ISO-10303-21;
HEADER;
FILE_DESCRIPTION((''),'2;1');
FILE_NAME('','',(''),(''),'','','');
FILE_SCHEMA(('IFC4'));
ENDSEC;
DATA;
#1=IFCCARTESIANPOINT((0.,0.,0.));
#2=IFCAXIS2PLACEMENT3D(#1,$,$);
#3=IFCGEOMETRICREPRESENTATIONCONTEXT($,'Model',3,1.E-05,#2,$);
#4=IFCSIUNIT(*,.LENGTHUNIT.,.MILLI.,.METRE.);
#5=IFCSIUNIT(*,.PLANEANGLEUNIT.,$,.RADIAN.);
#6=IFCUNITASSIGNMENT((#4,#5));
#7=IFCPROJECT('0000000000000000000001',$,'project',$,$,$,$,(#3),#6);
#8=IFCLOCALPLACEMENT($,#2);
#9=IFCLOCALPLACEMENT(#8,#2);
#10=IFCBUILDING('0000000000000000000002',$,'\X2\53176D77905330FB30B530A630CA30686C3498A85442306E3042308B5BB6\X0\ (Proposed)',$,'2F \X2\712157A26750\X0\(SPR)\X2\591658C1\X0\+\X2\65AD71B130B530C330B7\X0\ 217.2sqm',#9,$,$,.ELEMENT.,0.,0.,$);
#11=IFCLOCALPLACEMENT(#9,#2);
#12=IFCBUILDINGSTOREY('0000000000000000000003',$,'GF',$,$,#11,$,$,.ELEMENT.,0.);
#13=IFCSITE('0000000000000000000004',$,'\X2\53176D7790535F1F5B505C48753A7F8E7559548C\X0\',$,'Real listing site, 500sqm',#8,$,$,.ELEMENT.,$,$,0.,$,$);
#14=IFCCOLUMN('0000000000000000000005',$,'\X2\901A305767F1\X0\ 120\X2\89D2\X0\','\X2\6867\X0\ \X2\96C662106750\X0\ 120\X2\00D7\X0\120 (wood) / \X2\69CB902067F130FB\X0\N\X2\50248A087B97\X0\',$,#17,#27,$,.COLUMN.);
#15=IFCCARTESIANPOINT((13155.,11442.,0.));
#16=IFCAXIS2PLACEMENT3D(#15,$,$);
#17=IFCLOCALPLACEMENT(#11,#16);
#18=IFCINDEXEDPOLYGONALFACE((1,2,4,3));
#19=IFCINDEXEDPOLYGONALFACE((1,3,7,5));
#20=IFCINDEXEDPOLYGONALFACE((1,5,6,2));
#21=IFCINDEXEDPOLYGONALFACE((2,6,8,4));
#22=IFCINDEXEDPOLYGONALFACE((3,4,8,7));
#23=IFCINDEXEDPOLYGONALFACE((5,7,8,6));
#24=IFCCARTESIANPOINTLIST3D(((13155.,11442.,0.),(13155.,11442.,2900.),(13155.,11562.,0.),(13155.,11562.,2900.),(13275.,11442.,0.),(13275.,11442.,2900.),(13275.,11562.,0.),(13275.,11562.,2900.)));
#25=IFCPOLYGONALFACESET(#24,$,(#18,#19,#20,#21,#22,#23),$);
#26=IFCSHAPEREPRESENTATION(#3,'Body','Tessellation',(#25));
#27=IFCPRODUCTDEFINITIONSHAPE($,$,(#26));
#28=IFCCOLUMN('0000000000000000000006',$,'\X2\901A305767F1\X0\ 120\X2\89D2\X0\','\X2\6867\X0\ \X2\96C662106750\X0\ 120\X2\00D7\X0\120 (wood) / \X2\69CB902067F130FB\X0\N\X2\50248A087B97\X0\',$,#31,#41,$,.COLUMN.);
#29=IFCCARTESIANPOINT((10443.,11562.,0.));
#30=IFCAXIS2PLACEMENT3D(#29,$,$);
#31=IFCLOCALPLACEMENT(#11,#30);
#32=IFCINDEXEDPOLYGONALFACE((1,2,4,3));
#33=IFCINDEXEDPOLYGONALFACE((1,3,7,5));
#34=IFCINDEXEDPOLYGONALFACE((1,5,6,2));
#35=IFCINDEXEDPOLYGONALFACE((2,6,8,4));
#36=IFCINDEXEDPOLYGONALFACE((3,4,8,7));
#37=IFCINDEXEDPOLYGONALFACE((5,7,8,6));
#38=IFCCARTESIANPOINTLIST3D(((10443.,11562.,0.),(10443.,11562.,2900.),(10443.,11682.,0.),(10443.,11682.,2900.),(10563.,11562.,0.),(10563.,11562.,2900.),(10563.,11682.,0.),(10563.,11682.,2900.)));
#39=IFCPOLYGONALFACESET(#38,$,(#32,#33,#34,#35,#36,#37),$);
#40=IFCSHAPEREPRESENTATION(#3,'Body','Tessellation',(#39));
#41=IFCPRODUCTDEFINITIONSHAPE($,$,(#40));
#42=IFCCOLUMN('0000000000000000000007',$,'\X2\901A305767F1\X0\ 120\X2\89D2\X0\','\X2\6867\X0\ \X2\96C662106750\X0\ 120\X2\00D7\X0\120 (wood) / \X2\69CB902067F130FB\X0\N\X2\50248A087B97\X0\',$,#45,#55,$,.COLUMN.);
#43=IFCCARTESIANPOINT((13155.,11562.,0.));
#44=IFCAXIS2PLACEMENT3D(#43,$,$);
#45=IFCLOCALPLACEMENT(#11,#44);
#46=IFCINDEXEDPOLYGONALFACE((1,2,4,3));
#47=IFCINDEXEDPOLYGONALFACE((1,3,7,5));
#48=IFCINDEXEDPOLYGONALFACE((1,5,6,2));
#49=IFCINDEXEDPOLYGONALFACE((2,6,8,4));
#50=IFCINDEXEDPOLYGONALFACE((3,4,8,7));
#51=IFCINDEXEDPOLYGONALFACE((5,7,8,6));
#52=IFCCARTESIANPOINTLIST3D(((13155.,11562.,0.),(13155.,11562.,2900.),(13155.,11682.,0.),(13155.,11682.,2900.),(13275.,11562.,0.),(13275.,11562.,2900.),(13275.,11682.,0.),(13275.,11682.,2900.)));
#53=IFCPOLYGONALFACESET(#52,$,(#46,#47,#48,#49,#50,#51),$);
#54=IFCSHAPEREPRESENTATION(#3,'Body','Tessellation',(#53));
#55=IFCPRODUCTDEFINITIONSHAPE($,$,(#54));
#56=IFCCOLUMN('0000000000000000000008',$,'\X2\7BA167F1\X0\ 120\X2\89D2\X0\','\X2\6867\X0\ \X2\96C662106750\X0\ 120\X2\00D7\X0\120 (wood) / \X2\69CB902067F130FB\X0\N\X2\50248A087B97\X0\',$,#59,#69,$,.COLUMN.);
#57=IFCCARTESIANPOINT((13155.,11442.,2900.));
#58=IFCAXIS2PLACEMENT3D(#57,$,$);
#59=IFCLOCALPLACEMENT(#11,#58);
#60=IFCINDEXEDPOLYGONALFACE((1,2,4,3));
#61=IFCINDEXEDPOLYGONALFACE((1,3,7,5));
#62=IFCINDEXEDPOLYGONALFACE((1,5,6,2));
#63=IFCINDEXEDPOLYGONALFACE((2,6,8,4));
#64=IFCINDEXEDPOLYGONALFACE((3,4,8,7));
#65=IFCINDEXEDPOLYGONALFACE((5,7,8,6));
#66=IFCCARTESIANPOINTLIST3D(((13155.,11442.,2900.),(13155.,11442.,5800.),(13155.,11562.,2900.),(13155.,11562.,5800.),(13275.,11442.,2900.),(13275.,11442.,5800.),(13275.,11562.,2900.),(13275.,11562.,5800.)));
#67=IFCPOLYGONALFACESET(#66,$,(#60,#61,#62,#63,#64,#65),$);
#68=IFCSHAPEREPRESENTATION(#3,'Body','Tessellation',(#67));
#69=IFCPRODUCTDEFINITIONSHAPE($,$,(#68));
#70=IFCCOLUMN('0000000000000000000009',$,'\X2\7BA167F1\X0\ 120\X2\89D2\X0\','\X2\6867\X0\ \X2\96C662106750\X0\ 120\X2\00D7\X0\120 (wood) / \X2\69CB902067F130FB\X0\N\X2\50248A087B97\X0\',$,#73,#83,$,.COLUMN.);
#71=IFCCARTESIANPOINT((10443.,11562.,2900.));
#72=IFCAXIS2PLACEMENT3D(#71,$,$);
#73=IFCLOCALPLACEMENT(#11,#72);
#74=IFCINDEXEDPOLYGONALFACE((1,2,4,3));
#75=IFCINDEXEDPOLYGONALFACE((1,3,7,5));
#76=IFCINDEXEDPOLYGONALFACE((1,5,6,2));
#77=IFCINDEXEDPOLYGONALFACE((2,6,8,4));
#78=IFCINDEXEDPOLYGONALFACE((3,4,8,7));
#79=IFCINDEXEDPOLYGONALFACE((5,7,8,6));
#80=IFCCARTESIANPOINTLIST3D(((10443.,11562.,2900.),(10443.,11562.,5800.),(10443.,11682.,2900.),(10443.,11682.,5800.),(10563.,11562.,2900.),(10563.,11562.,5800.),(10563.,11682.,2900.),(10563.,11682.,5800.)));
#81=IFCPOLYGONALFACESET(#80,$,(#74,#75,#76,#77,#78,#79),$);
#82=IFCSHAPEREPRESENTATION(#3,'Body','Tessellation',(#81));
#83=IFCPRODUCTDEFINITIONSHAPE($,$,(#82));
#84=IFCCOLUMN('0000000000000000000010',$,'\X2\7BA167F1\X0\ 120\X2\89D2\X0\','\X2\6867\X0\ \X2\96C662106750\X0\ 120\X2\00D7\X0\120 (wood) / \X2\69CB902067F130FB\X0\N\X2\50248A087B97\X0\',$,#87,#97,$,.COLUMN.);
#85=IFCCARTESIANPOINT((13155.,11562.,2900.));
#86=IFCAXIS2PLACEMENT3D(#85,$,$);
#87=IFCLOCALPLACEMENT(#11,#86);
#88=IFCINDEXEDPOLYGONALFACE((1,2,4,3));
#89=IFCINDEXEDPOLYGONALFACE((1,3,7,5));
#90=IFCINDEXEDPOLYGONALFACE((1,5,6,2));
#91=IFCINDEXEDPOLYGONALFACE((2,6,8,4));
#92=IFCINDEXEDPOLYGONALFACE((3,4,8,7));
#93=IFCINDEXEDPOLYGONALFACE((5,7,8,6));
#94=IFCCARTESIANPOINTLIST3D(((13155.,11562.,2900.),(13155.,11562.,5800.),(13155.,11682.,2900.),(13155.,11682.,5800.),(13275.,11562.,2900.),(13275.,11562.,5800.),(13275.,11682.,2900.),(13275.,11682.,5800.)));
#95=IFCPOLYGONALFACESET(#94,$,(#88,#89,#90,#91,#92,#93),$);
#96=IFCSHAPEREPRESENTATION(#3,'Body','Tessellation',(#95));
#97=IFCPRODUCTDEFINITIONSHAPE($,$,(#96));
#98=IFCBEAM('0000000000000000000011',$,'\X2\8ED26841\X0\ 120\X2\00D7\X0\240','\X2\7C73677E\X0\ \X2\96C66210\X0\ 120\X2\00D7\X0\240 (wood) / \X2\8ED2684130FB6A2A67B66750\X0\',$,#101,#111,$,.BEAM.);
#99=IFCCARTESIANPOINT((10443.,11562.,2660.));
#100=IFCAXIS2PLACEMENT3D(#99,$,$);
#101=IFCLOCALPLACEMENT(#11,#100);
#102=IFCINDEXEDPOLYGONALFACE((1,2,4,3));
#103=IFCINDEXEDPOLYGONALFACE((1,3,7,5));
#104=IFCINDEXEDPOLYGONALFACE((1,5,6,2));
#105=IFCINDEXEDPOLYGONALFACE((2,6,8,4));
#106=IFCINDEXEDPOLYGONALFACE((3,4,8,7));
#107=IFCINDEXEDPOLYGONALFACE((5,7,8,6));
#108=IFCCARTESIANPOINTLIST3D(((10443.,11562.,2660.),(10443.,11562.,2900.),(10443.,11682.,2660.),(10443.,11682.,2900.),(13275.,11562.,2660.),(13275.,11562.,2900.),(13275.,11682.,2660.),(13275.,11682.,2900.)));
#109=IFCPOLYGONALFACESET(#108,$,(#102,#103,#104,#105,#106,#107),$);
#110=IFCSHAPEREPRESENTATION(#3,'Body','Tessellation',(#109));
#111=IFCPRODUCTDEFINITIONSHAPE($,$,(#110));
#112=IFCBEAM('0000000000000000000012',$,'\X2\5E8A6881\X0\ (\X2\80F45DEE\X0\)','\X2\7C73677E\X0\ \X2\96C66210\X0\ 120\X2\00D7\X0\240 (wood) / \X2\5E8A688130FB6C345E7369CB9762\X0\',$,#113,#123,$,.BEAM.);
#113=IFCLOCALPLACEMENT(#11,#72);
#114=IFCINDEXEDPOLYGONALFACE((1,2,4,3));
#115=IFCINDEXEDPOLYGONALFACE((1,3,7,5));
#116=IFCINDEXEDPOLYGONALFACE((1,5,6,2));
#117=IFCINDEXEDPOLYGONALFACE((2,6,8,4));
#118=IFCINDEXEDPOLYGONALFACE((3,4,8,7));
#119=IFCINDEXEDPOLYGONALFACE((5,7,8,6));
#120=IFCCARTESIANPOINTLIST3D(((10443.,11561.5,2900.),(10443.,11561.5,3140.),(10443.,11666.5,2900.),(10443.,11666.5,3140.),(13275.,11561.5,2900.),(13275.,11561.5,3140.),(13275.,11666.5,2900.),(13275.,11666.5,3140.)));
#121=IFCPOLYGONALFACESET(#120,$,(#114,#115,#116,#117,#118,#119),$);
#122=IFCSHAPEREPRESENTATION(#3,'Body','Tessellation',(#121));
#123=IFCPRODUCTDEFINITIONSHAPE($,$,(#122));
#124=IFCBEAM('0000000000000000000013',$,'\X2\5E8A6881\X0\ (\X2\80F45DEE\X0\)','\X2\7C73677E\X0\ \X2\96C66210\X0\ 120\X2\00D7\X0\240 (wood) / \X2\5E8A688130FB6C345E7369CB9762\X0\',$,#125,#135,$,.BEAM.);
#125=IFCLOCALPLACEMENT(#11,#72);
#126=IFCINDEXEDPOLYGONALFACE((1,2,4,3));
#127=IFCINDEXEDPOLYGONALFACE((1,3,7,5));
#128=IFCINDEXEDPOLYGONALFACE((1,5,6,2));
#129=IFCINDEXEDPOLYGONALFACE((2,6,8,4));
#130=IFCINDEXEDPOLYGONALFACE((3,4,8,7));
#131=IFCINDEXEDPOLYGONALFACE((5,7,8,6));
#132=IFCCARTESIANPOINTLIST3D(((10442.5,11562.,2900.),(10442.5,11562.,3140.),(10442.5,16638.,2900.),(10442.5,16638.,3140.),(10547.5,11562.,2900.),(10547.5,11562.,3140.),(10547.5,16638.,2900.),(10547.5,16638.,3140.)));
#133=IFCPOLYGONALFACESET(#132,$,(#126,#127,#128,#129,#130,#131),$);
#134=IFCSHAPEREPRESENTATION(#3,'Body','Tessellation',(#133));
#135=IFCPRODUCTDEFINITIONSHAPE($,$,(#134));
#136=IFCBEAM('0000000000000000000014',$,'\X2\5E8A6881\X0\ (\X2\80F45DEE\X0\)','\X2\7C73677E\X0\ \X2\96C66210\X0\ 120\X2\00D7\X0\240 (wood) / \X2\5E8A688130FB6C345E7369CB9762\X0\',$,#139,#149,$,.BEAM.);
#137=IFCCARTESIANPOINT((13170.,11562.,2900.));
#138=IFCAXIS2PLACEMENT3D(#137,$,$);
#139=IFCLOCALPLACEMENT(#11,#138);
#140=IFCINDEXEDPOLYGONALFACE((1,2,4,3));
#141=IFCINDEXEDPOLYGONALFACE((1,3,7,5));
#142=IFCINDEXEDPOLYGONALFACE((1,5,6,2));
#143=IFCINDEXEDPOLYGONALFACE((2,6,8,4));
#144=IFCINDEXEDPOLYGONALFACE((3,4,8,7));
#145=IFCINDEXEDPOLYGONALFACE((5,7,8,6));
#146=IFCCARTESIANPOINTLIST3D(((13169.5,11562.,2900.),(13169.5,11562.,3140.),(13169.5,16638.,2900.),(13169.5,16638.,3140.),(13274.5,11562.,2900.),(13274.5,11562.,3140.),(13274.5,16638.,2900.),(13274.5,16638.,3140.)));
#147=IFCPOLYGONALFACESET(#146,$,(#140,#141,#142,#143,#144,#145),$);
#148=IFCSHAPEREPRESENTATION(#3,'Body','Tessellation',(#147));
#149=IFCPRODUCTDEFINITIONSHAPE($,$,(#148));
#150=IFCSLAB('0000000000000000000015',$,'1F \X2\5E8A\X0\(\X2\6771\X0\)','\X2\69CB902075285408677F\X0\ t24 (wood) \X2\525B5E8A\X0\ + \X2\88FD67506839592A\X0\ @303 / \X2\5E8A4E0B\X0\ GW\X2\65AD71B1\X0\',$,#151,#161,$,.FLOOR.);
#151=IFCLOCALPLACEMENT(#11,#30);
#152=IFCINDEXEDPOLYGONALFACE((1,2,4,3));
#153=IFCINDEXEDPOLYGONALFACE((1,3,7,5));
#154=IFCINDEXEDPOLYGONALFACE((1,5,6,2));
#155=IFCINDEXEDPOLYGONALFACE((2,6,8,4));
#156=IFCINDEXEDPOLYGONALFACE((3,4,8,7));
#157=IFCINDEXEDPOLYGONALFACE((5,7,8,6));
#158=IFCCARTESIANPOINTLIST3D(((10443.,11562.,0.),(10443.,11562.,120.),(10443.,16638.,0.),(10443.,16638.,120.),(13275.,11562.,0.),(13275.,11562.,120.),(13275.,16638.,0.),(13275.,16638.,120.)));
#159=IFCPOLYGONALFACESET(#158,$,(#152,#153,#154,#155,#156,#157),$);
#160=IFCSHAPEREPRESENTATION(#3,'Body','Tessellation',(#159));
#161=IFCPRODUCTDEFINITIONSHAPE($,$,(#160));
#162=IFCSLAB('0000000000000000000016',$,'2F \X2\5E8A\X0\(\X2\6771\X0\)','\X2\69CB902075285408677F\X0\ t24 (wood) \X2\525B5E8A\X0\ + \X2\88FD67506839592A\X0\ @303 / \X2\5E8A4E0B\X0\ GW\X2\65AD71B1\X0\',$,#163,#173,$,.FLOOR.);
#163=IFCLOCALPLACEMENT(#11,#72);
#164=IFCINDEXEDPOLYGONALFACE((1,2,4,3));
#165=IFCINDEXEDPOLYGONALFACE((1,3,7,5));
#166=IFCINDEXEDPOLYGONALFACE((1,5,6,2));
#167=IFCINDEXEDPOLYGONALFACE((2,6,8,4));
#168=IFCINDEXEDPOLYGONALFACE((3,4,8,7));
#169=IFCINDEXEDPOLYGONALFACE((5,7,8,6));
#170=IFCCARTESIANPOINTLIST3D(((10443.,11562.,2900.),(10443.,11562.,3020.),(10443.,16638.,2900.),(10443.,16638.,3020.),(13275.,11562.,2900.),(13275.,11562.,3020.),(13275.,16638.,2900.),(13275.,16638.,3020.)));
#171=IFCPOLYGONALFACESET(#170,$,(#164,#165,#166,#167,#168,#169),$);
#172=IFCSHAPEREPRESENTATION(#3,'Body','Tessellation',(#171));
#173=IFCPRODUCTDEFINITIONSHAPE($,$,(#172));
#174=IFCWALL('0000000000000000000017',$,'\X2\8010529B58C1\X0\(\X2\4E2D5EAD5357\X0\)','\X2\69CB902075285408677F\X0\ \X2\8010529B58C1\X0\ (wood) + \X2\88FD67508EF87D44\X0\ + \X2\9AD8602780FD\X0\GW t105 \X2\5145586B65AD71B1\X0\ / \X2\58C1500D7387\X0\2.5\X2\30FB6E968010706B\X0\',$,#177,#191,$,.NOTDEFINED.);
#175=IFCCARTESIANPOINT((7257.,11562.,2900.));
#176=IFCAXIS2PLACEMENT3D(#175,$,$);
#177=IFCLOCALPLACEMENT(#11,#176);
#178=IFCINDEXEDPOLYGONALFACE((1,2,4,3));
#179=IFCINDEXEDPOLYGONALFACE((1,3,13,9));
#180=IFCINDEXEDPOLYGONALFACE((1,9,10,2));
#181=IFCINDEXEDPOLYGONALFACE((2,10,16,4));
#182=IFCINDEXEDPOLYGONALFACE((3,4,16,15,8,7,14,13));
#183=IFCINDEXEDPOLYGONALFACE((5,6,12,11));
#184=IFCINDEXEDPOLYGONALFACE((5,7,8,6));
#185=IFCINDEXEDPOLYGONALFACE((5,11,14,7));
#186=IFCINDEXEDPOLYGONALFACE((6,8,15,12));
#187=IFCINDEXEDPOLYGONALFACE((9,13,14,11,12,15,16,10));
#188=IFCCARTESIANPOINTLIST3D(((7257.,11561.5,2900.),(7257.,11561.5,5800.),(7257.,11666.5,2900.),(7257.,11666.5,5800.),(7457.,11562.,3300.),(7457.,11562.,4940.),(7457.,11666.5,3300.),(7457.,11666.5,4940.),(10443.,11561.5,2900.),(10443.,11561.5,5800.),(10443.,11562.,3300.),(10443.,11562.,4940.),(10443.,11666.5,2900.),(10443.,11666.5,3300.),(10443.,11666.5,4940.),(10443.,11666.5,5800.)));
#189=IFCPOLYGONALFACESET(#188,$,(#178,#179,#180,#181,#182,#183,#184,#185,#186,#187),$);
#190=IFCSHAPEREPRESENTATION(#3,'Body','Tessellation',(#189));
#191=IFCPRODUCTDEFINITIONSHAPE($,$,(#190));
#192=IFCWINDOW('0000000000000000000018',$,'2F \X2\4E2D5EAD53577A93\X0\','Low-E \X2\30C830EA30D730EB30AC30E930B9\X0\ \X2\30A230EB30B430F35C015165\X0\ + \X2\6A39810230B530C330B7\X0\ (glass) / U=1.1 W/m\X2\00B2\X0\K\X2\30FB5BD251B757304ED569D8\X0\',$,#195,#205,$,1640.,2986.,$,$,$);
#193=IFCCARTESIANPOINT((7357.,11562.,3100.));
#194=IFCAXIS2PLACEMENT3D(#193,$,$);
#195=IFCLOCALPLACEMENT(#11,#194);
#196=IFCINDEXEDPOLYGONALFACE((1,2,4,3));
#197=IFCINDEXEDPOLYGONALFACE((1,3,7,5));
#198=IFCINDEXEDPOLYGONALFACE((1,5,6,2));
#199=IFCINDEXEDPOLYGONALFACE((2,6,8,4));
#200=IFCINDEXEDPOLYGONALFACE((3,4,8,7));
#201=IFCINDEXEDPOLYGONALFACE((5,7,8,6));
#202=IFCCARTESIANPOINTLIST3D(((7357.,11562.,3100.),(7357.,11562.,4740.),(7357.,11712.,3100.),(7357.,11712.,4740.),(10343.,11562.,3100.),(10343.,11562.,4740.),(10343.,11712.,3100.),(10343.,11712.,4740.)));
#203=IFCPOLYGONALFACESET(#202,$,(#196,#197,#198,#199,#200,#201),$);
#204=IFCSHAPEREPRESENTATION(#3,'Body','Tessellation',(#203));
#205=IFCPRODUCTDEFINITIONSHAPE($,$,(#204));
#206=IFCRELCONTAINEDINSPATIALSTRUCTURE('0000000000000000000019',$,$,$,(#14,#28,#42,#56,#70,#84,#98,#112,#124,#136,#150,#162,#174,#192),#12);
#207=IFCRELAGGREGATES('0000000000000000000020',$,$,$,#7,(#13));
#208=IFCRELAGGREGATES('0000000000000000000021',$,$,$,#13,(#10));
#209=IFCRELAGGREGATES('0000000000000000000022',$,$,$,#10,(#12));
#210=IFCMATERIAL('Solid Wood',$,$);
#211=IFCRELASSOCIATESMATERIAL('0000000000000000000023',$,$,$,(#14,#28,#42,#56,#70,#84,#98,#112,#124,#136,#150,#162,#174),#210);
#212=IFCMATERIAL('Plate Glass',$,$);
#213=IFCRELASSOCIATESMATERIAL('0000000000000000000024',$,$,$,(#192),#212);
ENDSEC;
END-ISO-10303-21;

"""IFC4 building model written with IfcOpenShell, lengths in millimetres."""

from ifc_helpers import new_model, si_unit, frame, frame_2d, origin, place, context, project, spatial, rectangle, extrude, material, element, fill, save


model = new_model("IFC4")

# Units and contexts
model_context = context("Model", 3, precision=1e-05, world=origin())
ifc_project = project(units=[si_unit("LENGTHUNIT", "METRE", prefix="MILLI"), si_unit("PLANEANGLEUNIT", "RADIAN")], contexts=[model_context])

# Site, building, storey
site_placement = place(None, origin())
site = spatial("IfcSite", under=ifc_project, at=site_placement, Name="北海道弟子屈町美留和", ObjectType="Real listing site, 500sqm", CompositionType="ELEMENT", RefElevation=0.0)
building_placement = place(site_placement, origin())
building = spatial("IfcBuilding", under=site, at=building_placement, Name="北海道・サウナと水風呂のある家 (Proposed)", ObjectType="2F 無垢材(SPR)外壁+断熱サッシ 217.2sqm", CompositionType="ELEMENT", ElevationOfRefHeight=0.0, ElevationOfTerrain=0.0)
storey_placement = place(building_placement, origin())
storey = spatial("IfcBuildingStorey", under=building, at=storey_placement, Name="GF", CompositionType="ELEMENT", Elevation=0.0)

# Columns
ifc_material_1 = material(Name="Solid Wood")
column_1_placement = place(storey_placement, frame((13155.0, 11442.0, 0.0)))
element("IfcColumn", 1, at=column_1_placement, inside=storey, material=ifc_material_1, Name="通し柱 120角", Description="桧 集成材 120×120 (wood) / 構造柱・N値計算", PredefinedType="COLUMN", context=model_context, shape_type="SweptSolid", body=[
    extrude(rectangle(XDim=120.0, YDim=120.0, at=frame_2d((60.0, 60.0))), frame((13155.0, 11442.0, 0.0)), (0.0, 0.0, 1.0), 2900.0),
])
column_2_placement = place(storey_placement, frame((10443.0, 11562.0, 0.0)))
element("IfcColumn", 2, at=column_2_placement, inside=storey, material=ifc_material_1, Name="通し柱 120角", Description="桧 集成材 120×120 (wood) / 構造柱・N値計算", PredefinedType="COLUMN", context=model_context, shape_type="SweptSolid", body=[
    extrude(rectangle(XDim=120.0, YDim=120.0, at=frame_2d((60.0, 60.0))), frame((10443.0, 11562.0, 0.0)), (0.0, 0.0, 1.0), 2900.0),
])
column_3_placement = place(storey_placement, frame((13155.0, 11562.0, 0.0)))
element("IfcColumn", 3, at=column_3_placement, inside=storey, material=ifc_material_1, Name="通し柱 120角", Description="桧 集成材 120×120 (wood) / 構造柱・N値計算", PredefinedType="COLUMN", context=model_context, shape_type="SweptSolid", body=[
    extrude(rectangle(XDim=120.0, YDim=120.0, at=frame_2d((60.0, 60.0))), frame((13155.0, 11562.0, 0.0)), (0.0, 0.0, 1.0), 2900.0),
])
column_4_placement = place(storey_placement, frame((13155.0, 11442.0, 2900.0)))
element("IfcColumn", 4, at=column_4_placement, inside=storey, material=ifc_material_1, Name="管柱 120角", Description="桧 集成材 120×120 (wood) / 構造柱・N値計算", PredefinedType="COLUMN", context=model_context, shape_type="SweptSolid", body=[
    extrude(rectangle(XDim=120.0, YDim=120.0, at=frame_2d((60.0, 60.0))), frame((13155.0, 11442.0, 2900.0)), (0.0, 0.0, 1.0), 2900.0),
])
column_5_placement = place(storey_placement, frame((10443.0, 11562.0, 2900.0)))
element("IfcColumn", 5, at=column_5_placement, inside=storey, material=ifc_material_1, Name="管柱 120角", Description="桧 集成材 120×120 (wood) / 構造柱・N値計算", PredefinedType="COLUMN", context=model_context, shape_type="SweptSolid", body=[
    extrude(rectangle(XDim=120.0, YDim=120.0, at=frame_2d((60.0, 60.0))), frame((10443.0, 11562.0, 2900.0)), (0.0, 0.0, 1.0), 2900.0),
])
column_6_placement = place(storey_placement, frame((13155.0, 11562.0, 2900.0)))
element("IfcColumn", 6, at=column_6_placement, inside=storey, material=ifc_material_1, Name="管柱 120角", Description="桧 集成材 120×120 (wood) / 構造柱・N値計算", PredefinedType="COLUMN", context=model_context, shape_type="SweptSolid", body=[
    extrude(rectangle(XDim=120.0, YDim=120.0, at=frame_2d((60.0, 60.0))), frame((13155.0, 11562.0, 2900.0)), (0.0, 0.0, 1.0), 2900.0),
])

# Beams
beam_1_placement = place(storey_placement, frame((10443.0, 11562.0, 2660.0)))
element("IfcBeam", 7, at=beam_1_placement, inside=storey, material=ifc_material_1, Name="軒桁 120×240", Description="米松 集成 120×240 (wood) / 軒桁・横架材", PredefinedType="BEAM", context=model_context, shape_type="SweptSolid", body=[
    extrude(rectangle(XDim=2832.0, YDim=120.0, at=frame_2d((1416.0, 60.0))), frame((10443.0, 11562.0, 2660.0)), (0.0, 0.0, 1.0), 240.0),
])
beam_2_placement = place(storey_placement, frame((10443.0, 11562.0, 2900.0)))
element("IfcBeam", 8, at=beam_2_placement, inside=storey, material=ifc_material_1, Name="床梁 (胴差)", Description="米松 集成 120×240 (wood) / 床梁・水平構面", PredefinedType="BEAM", context=model_context, shape_type="SweptSolid", body=[
    extrude(rectangle(XDim=2832.0, YDim=105.0, at=frame_2d((1416.0, 52.0))), frame((10443.0, 11562.0, 2900.0)), (0.0, 0.0, 1.0), 240.0),
])
beam_3_placement = place(storey_placement, frame((10443.0, 11562.0, 2900.0)))
element("IfcBeam", 9, at=beam_3_placement, inside=storey, material=ifc_material_1, Name="床梁 (胴差)", Description="米松 集成 120×240 (wood) / 床梁・水平構面", PredefinedType="BEAM", context=model_context, shape_type="SweptSolid", body=[
    extrude(rectangle(XDim=105.0, YDim=5076.0, at=frame_2d((52.0, 2538.0))), frame((10443.0, 11562.0, 2900.0)), (0.0, 0.0, 1.0), 240.0),
])
beam_4_placement = place(storey_placement, frame((13170.0, 11562.0, 2900.0)))
element("IfcBeam", 10, at=beam_4_placement, inside=storey, material=ifc_material_1, Name="床梁 (胴差)", Description="米松 集成 120×240 (wood) / 床梁・水平構面", PredefinedType="BEAM", context=model_context, shape_type="SweptSolid", body=[
    extrude(rectangle(XDim=105.0, YDim=5076.0, at=frame_2d((52.0, 2538.0))), frame((13170.0, 11562.0, 2900.0)), (0.0, 0.0, 1.0), 240.0),
])

# Slabs
slab_1_placement = place(storey_placement, frame((10443.0, 11562.0, 0.0)))
element("IfcSlab", 11, at=slab_1_placement, inside=storey, material=ifc_material_1, Name="1F 床(東)", Description="構造用合板 t24 (wood) 剛床 + 製材根太 @303 / 床下 GW断熱", PredefinedType="FLOOR", context=model_context, shape_type="SweptSolid", body=[
    extrude(rectangle(XDim=2832.0, YDim=5076.0, at=frame_2d((1416.0, 2538.0))), frame((10443.0, 11562.0, 0.0)), (0.0, 0.0, 1.0), 120.0),
])
slab_2_placement = place(storey_placement, frame((10443.0, 11562.0, 2900.0)))
element("IfcSlab", 12, at=slab_2_placement, inside=storey, material=ifc_material_1, Name="2F 床(東)", Description="構造用合板 t24 (wood) 剛床 + 製材根太 @303 / 床下 GW断熱", PredefinedType="FLOOR", context=model_context, shape_type="SweptSolid", body=[
    extrude(rectangle(XDim=2832.0, YDim=5076.0, at=frame_2d((1416.0, 2538.0))), frame((10443.0, 11562.0, 2900.0)), (0.0, 0.0, 1.0), 120.0),
])

# Wall, opening, window
wall_1_placement = place(storey_placement, frame((7257.0, 11562.0, 2900.0)))
wall_1 = element("IfcWall", 13, at=wall_1_placement, inside=storey, material=ifc_material_1, Name="耐力壁(中庭南)", Description="構造用合板 耐力壁 (wood) + 製材軸組 + 高性能GW t105 充填断熱 / 壁倍率2.5・準耐火", PredefinedType="NOTDEFINED", context=model_context, shape_type="SweptSolid", body=[
    extrude(rectangle(XDim=3186.0, YDim=105.0, at=frame_2d((1593.0, 52.0))), frame((7257.0, 11562.0, 2900.0)), (0.0, 0.0, 1.0), 2900.0),
])
opening_placement = place(storey_placement, frame((7357.0, 11562.0, 3100.0)))
opening = element("IfcOpeningElement", 14, at=opening_placement, cuts=wall_1, PredefinedType="NOTDEFINED", context=model_context, shape_type="SweptSolid", body=[
    extrude(rectangle(XDim=2986.0, YDim=150.0, at=frame_2d((1493.0, 75.0))), frame((7357.0, 11562.0, 3100.0)), (0.0, 0.0, 1.0), 1640.0),
])
ifc_material_2 = material(Name="Plate Glass")
window_placement = place(storey_placement, frame((7357.0, 11562.0, 3100.0)))
window = element("IfcWindow", 15, at=window_placement, inside=storey, material=ifc_material_2, Name="2F 中庭南窓", Description="Low-E トリプルガラス アルゴン封入 + 樹脂サッシ (glass) / U=1.1 W/m²K・寒冷地仕様", OverallHeight=1640.0, OverallWidth=2986.0, context=model_context, shape_type="SweptSolid", body=[
    extrude(rectangle(XDim=2986.0, YDim=150.0, at=frame_2d((1493.0, 75.0))), frame((7357.0, 11562.0, 3100.0)), (0.0, 0.0, 1.0), 1640.0),
])
fill(opening, window)

save(model, "model.ifc")
